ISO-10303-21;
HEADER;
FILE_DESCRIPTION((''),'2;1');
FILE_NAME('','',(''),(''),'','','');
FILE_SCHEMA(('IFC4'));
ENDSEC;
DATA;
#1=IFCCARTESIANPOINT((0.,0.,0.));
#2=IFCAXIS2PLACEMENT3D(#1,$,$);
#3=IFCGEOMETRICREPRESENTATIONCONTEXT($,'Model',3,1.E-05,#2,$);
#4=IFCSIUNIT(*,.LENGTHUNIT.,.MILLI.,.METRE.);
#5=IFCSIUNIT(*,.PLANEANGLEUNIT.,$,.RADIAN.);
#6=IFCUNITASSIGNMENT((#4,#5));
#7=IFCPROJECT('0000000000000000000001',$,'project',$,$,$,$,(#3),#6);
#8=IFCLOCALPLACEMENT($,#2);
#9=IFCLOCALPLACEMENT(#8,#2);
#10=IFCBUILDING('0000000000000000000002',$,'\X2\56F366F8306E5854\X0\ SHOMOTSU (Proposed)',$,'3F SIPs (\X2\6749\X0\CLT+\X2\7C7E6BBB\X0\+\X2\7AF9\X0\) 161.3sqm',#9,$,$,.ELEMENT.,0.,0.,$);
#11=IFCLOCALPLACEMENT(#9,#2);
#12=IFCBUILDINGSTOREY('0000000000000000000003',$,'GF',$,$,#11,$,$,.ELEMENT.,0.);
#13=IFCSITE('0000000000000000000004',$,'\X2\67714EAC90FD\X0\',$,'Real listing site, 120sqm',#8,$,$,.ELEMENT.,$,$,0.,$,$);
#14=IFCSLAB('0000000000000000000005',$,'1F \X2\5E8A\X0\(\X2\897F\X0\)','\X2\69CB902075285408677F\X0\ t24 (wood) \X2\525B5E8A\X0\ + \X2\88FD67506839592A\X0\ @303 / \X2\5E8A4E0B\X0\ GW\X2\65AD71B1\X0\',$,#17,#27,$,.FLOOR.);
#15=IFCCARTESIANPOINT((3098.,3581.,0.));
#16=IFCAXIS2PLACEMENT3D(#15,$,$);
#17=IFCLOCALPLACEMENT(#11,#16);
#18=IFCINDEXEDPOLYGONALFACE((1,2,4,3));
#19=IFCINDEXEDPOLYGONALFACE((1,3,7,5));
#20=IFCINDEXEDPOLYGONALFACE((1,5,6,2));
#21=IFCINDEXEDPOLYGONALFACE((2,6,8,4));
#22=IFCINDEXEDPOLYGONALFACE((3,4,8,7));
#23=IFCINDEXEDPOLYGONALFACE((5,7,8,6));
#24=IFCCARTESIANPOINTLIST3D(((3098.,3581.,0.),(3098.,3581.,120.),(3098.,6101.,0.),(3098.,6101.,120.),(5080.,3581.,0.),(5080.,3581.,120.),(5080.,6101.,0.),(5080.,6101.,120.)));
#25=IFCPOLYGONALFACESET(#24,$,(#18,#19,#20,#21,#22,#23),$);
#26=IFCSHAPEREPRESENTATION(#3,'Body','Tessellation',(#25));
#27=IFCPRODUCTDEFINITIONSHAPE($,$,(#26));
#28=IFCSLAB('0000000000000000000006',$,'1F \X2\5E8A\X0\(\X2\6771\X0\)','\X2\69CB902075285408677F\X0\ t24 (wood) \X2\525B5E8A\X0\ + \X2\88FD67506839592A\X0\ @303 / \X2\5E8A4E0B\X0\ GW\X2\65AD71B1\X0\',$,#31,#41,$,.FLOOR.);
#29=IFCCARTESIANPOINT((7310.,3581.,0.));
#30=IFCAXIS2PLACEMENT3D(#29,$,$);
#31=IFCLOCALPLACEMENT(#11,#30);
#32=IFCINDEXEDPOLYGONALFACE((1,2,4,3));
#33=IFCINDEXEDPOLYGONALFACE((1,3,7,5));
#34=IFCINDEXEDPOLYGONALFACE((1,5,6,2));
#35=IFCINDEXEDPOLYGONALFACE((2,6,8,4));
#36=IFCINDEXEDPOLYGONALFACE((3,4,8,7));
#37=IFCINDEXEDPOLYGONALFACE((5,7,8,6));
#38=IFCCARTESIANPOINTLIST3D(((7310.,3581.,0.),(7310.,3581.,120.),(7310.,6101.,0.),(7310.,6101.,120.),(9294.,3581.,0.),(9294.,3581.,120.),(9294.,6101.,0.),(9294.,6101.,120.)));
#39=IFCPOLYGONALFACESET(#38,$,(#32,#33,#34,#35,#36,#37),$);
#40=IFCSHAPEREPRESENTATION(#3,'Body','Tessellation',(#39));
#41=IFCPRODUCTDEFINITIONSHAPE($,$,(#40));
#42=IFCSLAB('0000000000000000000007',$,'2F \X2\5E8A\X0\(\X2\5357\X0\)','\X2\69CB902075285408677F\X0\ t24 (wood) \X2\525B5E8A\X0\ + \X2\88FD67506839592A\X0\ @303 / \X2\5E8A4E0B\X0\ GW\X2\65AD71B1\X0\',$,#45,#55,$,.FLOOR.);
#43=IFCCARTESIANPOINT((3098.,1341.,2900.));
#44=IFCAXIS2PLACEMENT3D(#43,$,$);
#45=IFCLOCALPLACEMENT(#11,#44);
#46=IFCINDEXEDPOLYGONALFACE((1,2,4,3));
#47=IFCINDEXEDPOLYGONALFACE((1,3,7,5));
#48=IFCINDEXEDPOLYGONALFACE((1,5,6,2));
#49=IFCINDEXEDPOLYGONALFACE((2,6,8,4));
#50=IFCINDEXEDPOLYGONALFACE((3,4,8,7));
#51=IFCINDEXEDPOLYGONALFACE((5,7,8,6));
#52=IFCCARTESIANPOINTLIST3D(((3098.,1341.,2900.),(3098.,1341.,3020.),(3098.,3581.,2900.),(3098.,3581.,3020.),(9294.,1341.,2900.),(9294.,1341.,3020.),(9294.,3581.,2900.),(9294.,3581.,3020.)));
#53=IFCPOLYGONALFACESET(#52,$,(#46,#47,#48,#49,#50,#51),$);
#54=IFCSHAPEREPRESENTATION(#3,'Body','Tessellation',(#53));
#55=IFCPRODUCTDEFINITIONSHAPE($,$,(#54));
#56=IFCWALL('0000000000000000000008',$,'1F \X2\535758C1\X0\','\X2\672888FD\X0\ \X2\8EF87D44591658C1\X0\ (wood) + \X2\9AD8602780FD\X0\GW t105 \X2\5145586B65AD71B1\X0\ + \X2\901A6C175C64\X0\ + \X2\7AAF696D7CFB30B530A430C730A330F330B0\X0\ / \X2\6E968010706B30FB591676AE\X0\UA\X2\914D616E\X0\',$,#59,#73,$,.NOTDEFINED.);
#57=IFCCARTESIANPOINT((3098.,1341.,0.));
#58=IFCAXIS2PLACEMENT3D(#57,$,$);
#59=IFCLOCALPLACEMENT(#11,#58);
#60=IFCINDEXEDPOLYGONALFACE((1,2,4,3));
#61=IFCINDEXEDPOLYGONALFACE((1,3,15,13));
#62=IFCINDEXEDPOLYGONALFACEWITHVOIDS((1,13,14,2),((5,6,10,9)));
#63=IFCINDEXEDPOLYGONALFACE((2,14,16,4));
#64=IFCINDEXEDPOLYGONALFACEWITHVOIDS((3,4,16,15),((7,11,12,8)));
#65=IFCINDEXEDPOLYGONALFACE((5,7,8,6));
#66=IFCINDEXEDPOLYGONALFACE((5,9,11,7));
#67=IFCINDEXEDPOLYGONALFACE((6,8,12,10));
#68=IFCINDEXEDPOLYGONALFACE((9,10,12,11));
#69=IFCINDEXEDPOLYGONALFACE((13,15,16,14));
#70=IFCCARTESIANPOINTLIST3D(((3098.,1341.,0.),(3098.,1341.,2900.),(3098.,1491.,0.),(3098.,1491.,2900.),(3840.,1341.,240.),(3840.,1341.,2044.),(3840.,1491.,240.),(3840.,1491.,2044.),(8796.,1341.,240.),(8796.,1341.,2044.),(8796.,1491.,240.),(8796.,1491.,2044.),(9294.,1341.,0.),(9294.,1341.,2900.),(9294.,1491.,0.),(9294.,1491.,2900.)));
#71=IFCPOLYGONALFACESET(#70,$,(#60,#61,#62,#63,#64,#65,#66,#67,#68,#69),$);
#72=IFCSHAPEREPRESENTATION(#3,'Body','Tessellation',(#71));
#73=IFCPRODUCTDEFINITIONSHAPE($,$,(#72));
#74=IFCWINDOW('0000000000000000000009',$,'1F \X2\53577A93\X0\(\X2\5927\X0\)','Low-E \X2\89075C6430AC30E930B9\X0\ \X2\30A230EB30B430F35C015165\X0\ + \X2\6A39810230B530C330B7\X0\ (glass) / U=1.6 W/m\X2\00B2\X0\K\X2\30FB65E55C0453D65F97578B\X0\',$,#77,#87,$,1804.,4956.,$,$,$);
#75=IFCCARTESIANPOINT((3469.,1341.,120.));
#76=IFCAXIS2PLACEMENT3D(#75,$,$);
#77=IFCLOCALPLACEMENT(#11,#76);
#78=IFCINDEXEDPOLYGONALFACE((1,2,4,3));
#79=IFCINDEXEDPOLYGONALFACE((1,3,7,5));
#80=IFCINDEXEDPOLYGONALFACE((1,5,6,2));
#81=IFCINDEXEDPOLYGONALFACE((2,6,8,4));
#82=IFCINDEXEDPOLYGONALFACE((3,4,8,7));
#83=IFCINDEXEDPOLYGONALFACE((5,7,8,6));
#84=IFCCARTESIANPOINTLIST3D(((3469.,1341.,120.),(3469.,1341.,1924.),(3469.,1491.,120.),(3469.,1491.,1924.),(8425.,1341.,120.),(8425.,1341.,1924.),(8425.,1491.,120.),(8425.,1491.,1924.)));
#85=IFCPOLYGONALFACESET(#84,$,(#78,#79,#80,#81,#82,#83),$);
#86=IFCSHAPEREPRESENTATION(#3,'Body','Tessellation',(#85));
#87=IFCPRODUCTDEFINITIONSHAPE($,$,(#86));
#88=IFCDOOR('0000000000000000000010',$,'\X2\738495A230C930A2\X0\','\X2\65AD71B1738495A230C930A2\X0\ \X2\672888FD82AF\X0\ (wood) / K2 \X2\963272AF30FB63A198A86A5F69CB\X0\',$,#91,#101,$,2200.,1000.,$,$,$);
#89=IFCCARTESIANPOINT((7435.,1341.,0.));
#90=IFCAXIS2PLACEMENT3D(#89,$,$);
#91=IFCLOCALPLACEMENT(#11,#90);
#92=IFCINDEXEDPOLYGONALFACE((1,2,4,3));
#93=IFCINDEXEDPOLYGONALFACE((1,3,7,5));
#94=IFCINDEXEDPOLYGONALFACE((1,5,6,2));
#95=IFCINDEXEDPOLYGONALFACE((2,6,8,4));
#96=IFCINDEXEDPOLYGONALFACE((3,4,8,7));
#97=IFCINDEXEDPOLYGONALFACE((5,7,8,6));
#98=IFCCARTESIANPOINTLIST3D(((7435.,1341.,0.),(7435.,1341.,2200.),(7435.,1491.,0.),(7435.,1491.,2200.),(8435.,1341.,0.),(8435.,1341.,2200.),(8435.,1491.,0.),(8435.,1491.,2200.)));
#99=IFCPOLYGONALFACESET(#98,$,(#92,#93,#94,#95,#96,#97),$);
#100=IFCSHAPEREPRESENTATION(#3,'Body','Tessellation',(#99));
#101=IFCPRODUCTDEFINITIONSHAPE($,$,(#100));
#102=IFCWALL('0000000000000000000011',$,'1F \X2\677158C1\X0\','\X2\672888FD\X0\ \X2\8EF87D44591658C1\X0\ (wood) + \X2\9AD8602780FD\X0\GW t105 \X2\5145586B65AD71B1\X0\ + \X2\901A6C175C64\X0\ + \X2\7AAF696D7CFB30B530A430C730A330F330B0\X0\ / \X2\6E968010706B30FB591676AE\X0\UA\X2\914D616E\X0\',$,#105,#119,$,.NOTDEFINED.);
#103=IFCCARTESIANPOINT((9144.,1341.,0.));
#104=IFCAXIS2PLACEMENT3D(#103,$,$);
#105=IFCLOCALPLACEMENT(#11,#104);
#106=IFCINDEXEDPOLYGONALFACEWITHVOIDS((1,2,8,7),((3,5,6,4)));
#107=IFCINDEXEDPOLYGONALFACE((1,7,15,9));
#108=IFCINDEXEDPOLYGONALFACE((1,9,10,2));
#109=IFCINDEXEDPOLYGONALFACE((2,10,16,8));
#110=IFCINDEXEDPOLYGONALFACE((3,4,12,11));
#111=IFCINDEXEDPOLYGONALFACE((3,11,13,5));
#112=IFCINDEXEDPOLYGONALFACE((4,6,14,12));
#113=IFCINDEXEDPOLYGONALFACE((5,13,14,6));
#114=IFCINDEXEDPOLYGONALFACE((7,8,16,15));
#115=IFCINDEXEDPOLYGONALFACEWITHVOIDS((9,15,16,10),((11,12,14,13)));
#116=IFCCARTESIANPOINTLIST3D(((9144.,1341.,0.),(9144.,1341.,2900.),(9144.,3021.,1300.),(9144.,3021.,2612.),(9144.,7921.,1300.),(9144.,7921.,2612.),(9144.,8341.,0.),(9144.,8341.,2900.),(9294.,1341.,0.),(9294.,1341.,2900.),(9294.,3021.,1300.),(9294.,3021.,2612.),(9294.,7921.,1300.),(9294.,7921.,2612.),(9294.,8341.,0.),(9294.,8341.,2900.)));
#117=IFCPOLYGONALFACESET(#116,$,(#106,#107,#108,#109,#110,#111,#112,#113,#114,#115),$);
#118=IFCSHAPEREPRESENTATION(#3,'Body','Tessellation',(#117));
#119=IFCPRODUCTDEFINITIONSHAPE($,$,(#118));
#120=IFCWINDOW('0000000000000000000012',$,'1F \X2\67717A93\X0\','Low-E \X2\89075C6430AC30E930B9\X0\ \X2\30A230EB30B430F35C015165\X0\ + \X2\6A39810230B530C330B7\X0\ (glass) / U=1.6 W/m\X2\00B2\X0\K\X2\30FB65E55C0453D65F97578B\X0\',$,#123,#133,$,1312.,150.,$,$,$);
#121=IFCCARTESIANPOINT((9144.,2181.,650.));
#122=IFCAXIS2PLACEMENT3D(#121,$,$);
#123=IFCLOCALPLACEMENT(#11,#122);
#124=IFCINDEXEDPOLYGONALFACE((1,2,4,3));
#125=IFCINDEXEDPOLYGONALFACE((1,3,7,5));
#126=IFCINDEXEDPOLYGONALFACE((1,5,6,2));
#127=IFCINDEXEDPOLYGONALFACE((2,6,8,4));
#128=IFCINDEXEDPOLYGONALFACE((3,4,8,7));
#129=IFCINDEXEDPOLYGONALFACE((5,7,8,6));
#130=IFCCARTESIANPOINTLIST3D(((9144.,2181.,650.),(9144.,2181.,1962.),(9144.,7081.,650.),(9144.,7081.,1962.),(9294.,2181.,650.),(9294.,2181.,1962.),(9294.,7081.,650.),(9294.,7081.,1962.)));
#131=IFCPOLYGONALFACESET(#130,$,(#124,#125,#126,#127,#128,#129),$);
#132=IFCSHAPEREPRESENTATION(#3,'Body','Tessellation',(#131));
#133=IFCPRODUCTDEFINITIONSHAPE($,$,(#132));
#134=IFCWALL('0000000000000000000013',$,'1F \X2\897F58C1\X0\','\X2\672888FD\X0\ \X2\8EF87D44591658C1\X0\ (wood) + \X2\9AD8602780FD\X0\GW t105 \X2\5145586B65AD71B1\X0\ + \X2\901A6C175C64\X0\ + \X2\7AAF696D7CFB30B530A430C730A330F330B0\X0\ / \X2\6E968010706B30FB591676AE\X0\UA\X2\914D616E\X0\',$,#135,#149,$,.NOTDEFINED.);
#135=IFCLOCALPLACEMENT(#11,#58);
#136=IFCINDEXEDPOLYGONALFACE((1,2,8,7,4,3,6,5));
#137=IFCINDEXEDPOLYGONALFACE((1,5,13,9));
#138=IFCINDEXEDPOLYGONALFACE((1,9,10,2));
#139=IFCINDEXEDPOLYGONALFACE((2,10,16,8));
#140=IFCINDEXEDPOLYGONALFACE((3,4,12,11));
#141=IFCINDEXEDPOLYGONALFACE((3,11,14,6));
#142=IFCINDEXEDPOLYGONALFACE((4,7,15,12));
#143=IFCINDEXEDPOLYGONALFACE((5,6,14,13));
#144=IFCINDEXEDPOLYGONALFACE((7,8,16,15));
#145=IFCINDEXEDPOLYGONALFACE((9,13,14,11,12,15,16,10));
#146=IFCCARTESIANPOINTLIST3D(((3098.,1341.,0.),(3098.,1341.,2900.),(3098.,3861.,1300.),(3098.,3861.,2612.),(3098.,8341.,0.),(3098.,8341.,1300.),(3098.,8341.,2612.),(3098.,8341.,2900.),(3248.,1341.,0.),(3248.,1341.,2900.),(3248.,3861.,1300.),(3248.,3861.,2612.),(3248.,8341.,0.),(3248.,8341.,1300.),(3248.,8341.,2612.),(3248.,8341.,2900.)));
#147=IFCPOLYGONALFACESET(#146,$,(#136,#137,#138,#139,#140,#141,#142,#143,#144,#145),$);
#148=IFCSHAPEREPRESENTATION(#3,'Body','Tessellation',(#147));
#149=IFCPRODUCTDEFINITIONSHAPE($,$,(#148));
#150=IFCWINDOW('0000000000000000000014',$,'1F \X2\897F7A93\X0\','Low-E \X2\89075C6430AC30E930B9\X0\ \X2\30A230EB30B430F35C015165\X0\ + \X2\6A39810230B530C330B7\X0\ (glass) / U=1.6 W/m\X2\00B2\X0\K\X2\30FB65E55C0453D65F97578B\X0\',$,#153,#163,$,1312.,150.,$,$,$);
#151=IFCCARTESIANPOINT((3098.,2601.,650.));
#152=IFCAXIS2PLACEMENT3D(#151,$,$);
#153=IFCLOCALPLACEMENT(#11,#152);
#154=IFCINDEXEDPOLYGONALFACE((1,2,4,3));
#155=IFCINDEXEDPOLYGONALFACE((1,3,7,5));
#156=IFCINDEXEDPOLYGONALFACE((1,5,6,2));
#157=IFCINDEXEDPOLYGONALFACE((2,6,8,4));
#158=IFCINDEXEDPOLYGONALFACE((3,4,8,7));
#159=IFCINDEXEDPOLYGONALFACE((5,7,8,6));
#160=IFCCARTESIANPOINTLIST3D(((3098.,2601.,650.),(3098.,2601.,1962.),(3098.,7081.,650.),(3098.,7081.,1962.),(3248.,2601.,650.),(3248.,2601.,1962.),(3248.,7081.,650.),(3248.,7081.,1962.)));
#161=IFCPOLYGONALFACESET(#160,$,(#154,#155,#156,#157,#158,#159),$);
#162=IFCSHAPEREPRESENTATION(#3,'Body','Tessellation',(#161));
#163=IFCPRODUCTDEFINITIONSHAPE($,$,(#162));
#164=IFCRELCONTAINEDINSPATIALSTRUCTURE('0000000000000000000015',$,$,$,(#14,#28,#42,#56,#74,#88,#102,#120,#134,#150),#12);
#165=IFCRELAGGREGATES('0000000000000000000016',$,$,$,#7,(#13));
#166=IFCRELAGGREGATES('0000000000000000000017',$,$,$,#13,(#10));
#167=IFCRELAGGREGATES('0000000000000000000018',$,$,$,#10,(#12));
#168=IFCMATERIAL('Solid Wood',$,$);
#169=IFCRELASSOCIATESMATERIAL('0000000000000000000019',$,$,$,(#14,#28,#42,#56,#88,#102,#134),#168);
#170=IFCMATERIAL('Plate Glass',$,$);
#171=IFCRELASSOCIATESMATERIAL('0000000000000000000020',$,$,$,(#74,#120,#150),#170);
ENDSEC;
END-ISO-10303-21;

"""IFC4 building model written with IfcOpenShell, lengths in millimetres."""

from ifc_helpers import new_model, si_unit, frame, frame_2d, origin, place, context, project, spatial, rectangle, extrude, material, element, fill, save


model = new_model("IFC4")

# Units and contexts
model_context = context("Model", 3, precision=1e-05, world=origin())
ifc_project = project(units=[si_unit("LENGTHUNIT", "METRE", prefix="MILLI"), si_unit("PLANEANGLEUNIT", "RADIAN")], contexts=[model_context])

# Site, building, storey
site_placement = place(None, origin())
site = spatial("IfcSite", under=ifc_project, at=site_placement, Name="東京都", ObjectType="Real listing site, 120sqm", CompositionType="ELEMENT", RefElevation=0.0)
building_placement = place(site_placement, origin())
building = spatial("IfcBuilding", under=site, at=building_placement, Name="図書の塔 SHOMOTSU (Proposed)", ObjectType="3F SIPs (杉CLT+籾殻+竹) 161.3sqm", CompositionType="ELEMENT", ElevationOfRefHeight=0.0, ElevationOfTerrain=0.0)
storey_placement = place(building_placement, origin())
storey = spatial("IfcBuildingStorey", under=building, at=storey_placement, Name="GF", CompositionType="ELEMENT", Elevation=0.0)

# Slabs
ifc_material_1 = material(Name="Solid Wood")
slab_1_placement = place(storey_placement, frame((3098.0, 3581.0, 0.0)))
element("IfcSlab", 1, at=slab_1_placement, inside=storey, material=ifc_material_1, Name="1F 床(西)", Description="構造用合板 t24 (wood) 剛床 + 製材根太 @303 / 床下 GW断熱", PredefinedType="FLOOR", context=model_context, shape_type="SweptSolid", body=[
    extrude(rectangle(XDim=1982.0, YDim=2520.0, at=frame_2d((991.0, 1260.0))), frame((3098.0, 3581.0, 0.0)), (0.0, 0.0, 1.0), 120.0),
])
slab_2_placement = place(storey_placement, frame((7310.0, 3581.0, 0.0)))
element("IfcSlab", 2, at=slab_2_placement, inside=storey, material=ifc_material_1, Name="1F 床(東)", Description="構造用合板 t24 (wood) 剛床 + 製材根太 @303 / 床下 GW断熱", PredefinedType="FLOOR", context=model_context, shape_type="SweptSolid", body=[
    extrude(rectangle(XDim=1984.0, YDim=2520.0, at=frame_2d((992.0, 1260.0))), frame((7310.0, 3581.0, 0.0)), (0.0, 0.0, 1.0), 120.0),
])
slab_3_placement = place(storey_placement, frame((3098.0, 1341.0, 2900.0)))
element("IfcSlab", 3, at=slab_3_placement, inside=storey, material=ifc_material_1, Name="2F 床(南)", Description="構造用合板 t24 (wood) 剛床 + 製材根太 @303 / 床下 GW断熱", PredefinedType="FLOOR", context=model_context, shape_type="SweptSolid", body=[
    extrude(rectangle(XDim=6196.0, YDim=2240.0, at=frame_2d((3098.0, 1120.0))), frame((3098.0, 1341.0, 2900.0)), (0.0, 0.0, 1.0), 120.0),
])

# Wall, openings, window, door
wall_1_placement = place(storey_placement, frame((3098.0, 1341.0, 0.0)))
wall_1 = element("IfcWall", 4, at=wall_1_placement, inside=storey, material=ifc_material_1, Name="1F 南壁", Description="木製 軸組外壁 (wood) + 高性能GW t105 充填断熱 + 通気層 + 窯業系サイディング / 準耐火・外皮UA配慮", PredefinedType="NOTDEFINED", context=model_context, shape_type="SweptSolid", body=[
    extrude(rectangle(XDim=6196.0, YDim=150.0, at=frame_2d((3098.0, 75.0))), frame((3098.0, 1341.0, 0.0)), (0.0, 0.0, 1.0), 2900.0),
])
opening_1_placement = place(storey_placement, frame((3469.0, 1341.0, 120.0)))
opening_1 = element("IfcOpeningElement", 5, at=opening_1_placement, cuts=wall_1, PredefinedType="NOTDEFINED", context=model_context, shape_type="SweptSolid", body=[
    extrude(rectangle(XDim=4956.0, YDim=150.0, at=frame_2d((2478.0, 75.0))), frame((3469.0, 1341.0, 120.0)), (0.0, 0.0, 1.0), 1804.0),
])
opening_2_placement = place(storey_placement, frame((7435.0, 1341.0, 0.0)))
opening_2 = element("IfcOpeningElement", 6, at=opening_2_placement, cuts=wall_1, PredefinedType="NOTDEFINED", context=model_context, shape_type="SweptSolid", body=[
    extrude(rectangle(XDim=1000.0, YDim=150.0, at=frame_2d((500.0, 75.0))), frame((7435.0, 1341.0, 0.0)), (0.0, 0.0, 1.0), 2200.0),
])
ifc_material_2 = material(Name="Plate Glass")
window_1_placement = place(storey_placement, frame((3469.0, 1341.0, 120.0)))
window_1 = element("IfcWindow", 7, at=window_1_placement, inside=storey, material=ifc_material_2, Name="1F 南窓(大)", Description="Low-E 複層ガラス アルゴン封入 + 樹脂サッシ (glass) / U=1.6 W/m²K・日射取得型", OverallHeight=1804.0, OverallWidth=4956.0, context=model_context, shape_type="SweptSolid", body=[
    extrude(rectangle(XDim=4956.0, YDim=150.0, at=frame_2d((2478.0, 75.0))), frame((3469.0, 1341.0, 120.0)), (0.0, 0.0, 1.0), 1804.0),
])
fill(opening_1, window_1)
door_placement = place(storey_placement, frame((7435.0, 1341.0, 0.0)))
door = element("IfcDoor", 8, at=door_placement, inside=storey, material=ifc_material_1, Name="玄関ドア", Description="断熱玄関ドア 木製芯 (wood) / K2 防犯・採風機構", OverallHeight=2200.0, OverallWidth=1000.0, context=model_context, shape_type="SweptSolid", body=[
    extrude(rectangle(XDim=1000.0, YDim=150.0, at=frame_2d((500.0, 75.0))), frame((7435.0, 1341.0, 0.0)), (0.0, 0.0, 1.0), 2200.0),
])
fill(opening_2, door)

# Walls, openings, windows
wall_2_placement = place(storey_placement, frame((9144.0, 1341.0, 0.0)))
wall_2 = element("IfcWall", 9, at=wall_2_placement, inside=storey, material=ifc_material_1, Name="1F 東壁", Description="木製 軸組外壁 (wood) + 高性能GW t105 充填断熱 + 通気層 + 窯業系サイディング / 準耐火・外皮UA配慮", PredefinedType="NOTDEFINED", context=model_context, shape_type="SweptSolid", body=[
    extrude(rectangle(XDim=150.0, YDim=7000.0, at=frame_2d((75.0, 3500.0))), frame((9144.0, 1341.0, 0.0)), (0.0, 0.0, 1.0), 2900.0),
])
opening_3_placement = place(storey_placement, frame((9144.0, 2181.0, 650.0)))
opening_3 = element("IfcOpeningElement", 10, at=opening_3_placement, cuts=wall_2, PredefinedType="NOTDEFINED", context=model_context, shape_type="SweptSolid", body=[
    extrude(rectangle(XDim=150.0, YDim=4900.0, at=frame_2d((75.0, 2450.0))), frame((9144.0, 2181.0, 650.0)), (0.0, 0.0, 1.0), 1312.0),
])
window_2_placement = place(storey_placement, frame((9144.0, 2181.0, 650.0)))
window_2 = element("IfcWindow", 11, at=window_2_placement, inside=storey, material=ifc_material_2, Name="1F 東窓", Description="Low-E 複層ガラス アルゴン封入 + 樹脂サッシ (glass) / U=1.6 W/m²K・日射取得型", OverallHeight=1312.0, OverallWidth=150.0, context=model_context, shape_type="SweptSolid", body=[
    extrude(rectangle(XDim=150.0, YDim=4900.0, at=frame_2d((75.0, 2450.0))), frame((9144.0, 2181.0, 650.0)), (0.0, 0.0, 1.0), 1312.0),
])
fill(opening_3, window_2)
wall_3_placement = place(storey_placement, frame((3098.0, 1341.0, 0.0)))
wall_3 = element("IfcWall", 12, at=wall_3_placement, inside=storey, material=ifc_material_1, Name="1F 西壁", Description="木製 軸組外壁 (wood) + 高性能GW t105 充填断熱 + 通気層 + 窯業系サイディング / 準耐火・外皮UA配慮", PredefinedType="NOTDEFINED", context=model_context, shape_type="SweptSolid", body=[
    extrude(rectangle(XDim=150.0, YDim=7000.0, at=frame_2d((75.0, 3500.0))), frame((3098.0, 1341.0, 0.0)), (0.0, 0.0, 1.0), 2900.0),
])
opening_4_placement = place(storey_placement, frame((3098.0, 2601.0, 650.0)))
opening_4 = element("IfcOpeningElement", 13, at=opening_4_placement, cuts=wall_3, PredefinedType="NOTDEFINED", context=model_context, shape_type="SweptSolid", body=[
    extrude(rectangle(XDim=150.0, YDim=4480.0, at=frame_2d((75.0, 2240.0))), frame((3098.0, 2601.0, 650.0)), (0.0, 0.0, 1.0), 1312.0),
])
window_3_placement = place(storey_placement, frame((3098.0, 2601.0, 650.0)))
window_3 = element("IfcWindow", 14, at=window_3_placement, inside=storey, material=ifc_material_2, Name="1F 西窓", Description="Low-E 複層ガラス アルゴン封入 + 樹脂サッシ (glass) / U=1.6 W/m²K・日射取得型", OverallHeight=1312.0, OverallWidth=150.0, context=model_context, shape_type="SweptSolid", body=[
    extrude(rectangle(XDim=150.0, YDim=4480.0, at=frame_2d((75.0, 2240.0))), frame((3098.0, 2601.0, 650.0)), (0.0, 0.0, 1.0), 1312.0),
])
fill(opening_4, window_3)

save(model, "model.ifc")
